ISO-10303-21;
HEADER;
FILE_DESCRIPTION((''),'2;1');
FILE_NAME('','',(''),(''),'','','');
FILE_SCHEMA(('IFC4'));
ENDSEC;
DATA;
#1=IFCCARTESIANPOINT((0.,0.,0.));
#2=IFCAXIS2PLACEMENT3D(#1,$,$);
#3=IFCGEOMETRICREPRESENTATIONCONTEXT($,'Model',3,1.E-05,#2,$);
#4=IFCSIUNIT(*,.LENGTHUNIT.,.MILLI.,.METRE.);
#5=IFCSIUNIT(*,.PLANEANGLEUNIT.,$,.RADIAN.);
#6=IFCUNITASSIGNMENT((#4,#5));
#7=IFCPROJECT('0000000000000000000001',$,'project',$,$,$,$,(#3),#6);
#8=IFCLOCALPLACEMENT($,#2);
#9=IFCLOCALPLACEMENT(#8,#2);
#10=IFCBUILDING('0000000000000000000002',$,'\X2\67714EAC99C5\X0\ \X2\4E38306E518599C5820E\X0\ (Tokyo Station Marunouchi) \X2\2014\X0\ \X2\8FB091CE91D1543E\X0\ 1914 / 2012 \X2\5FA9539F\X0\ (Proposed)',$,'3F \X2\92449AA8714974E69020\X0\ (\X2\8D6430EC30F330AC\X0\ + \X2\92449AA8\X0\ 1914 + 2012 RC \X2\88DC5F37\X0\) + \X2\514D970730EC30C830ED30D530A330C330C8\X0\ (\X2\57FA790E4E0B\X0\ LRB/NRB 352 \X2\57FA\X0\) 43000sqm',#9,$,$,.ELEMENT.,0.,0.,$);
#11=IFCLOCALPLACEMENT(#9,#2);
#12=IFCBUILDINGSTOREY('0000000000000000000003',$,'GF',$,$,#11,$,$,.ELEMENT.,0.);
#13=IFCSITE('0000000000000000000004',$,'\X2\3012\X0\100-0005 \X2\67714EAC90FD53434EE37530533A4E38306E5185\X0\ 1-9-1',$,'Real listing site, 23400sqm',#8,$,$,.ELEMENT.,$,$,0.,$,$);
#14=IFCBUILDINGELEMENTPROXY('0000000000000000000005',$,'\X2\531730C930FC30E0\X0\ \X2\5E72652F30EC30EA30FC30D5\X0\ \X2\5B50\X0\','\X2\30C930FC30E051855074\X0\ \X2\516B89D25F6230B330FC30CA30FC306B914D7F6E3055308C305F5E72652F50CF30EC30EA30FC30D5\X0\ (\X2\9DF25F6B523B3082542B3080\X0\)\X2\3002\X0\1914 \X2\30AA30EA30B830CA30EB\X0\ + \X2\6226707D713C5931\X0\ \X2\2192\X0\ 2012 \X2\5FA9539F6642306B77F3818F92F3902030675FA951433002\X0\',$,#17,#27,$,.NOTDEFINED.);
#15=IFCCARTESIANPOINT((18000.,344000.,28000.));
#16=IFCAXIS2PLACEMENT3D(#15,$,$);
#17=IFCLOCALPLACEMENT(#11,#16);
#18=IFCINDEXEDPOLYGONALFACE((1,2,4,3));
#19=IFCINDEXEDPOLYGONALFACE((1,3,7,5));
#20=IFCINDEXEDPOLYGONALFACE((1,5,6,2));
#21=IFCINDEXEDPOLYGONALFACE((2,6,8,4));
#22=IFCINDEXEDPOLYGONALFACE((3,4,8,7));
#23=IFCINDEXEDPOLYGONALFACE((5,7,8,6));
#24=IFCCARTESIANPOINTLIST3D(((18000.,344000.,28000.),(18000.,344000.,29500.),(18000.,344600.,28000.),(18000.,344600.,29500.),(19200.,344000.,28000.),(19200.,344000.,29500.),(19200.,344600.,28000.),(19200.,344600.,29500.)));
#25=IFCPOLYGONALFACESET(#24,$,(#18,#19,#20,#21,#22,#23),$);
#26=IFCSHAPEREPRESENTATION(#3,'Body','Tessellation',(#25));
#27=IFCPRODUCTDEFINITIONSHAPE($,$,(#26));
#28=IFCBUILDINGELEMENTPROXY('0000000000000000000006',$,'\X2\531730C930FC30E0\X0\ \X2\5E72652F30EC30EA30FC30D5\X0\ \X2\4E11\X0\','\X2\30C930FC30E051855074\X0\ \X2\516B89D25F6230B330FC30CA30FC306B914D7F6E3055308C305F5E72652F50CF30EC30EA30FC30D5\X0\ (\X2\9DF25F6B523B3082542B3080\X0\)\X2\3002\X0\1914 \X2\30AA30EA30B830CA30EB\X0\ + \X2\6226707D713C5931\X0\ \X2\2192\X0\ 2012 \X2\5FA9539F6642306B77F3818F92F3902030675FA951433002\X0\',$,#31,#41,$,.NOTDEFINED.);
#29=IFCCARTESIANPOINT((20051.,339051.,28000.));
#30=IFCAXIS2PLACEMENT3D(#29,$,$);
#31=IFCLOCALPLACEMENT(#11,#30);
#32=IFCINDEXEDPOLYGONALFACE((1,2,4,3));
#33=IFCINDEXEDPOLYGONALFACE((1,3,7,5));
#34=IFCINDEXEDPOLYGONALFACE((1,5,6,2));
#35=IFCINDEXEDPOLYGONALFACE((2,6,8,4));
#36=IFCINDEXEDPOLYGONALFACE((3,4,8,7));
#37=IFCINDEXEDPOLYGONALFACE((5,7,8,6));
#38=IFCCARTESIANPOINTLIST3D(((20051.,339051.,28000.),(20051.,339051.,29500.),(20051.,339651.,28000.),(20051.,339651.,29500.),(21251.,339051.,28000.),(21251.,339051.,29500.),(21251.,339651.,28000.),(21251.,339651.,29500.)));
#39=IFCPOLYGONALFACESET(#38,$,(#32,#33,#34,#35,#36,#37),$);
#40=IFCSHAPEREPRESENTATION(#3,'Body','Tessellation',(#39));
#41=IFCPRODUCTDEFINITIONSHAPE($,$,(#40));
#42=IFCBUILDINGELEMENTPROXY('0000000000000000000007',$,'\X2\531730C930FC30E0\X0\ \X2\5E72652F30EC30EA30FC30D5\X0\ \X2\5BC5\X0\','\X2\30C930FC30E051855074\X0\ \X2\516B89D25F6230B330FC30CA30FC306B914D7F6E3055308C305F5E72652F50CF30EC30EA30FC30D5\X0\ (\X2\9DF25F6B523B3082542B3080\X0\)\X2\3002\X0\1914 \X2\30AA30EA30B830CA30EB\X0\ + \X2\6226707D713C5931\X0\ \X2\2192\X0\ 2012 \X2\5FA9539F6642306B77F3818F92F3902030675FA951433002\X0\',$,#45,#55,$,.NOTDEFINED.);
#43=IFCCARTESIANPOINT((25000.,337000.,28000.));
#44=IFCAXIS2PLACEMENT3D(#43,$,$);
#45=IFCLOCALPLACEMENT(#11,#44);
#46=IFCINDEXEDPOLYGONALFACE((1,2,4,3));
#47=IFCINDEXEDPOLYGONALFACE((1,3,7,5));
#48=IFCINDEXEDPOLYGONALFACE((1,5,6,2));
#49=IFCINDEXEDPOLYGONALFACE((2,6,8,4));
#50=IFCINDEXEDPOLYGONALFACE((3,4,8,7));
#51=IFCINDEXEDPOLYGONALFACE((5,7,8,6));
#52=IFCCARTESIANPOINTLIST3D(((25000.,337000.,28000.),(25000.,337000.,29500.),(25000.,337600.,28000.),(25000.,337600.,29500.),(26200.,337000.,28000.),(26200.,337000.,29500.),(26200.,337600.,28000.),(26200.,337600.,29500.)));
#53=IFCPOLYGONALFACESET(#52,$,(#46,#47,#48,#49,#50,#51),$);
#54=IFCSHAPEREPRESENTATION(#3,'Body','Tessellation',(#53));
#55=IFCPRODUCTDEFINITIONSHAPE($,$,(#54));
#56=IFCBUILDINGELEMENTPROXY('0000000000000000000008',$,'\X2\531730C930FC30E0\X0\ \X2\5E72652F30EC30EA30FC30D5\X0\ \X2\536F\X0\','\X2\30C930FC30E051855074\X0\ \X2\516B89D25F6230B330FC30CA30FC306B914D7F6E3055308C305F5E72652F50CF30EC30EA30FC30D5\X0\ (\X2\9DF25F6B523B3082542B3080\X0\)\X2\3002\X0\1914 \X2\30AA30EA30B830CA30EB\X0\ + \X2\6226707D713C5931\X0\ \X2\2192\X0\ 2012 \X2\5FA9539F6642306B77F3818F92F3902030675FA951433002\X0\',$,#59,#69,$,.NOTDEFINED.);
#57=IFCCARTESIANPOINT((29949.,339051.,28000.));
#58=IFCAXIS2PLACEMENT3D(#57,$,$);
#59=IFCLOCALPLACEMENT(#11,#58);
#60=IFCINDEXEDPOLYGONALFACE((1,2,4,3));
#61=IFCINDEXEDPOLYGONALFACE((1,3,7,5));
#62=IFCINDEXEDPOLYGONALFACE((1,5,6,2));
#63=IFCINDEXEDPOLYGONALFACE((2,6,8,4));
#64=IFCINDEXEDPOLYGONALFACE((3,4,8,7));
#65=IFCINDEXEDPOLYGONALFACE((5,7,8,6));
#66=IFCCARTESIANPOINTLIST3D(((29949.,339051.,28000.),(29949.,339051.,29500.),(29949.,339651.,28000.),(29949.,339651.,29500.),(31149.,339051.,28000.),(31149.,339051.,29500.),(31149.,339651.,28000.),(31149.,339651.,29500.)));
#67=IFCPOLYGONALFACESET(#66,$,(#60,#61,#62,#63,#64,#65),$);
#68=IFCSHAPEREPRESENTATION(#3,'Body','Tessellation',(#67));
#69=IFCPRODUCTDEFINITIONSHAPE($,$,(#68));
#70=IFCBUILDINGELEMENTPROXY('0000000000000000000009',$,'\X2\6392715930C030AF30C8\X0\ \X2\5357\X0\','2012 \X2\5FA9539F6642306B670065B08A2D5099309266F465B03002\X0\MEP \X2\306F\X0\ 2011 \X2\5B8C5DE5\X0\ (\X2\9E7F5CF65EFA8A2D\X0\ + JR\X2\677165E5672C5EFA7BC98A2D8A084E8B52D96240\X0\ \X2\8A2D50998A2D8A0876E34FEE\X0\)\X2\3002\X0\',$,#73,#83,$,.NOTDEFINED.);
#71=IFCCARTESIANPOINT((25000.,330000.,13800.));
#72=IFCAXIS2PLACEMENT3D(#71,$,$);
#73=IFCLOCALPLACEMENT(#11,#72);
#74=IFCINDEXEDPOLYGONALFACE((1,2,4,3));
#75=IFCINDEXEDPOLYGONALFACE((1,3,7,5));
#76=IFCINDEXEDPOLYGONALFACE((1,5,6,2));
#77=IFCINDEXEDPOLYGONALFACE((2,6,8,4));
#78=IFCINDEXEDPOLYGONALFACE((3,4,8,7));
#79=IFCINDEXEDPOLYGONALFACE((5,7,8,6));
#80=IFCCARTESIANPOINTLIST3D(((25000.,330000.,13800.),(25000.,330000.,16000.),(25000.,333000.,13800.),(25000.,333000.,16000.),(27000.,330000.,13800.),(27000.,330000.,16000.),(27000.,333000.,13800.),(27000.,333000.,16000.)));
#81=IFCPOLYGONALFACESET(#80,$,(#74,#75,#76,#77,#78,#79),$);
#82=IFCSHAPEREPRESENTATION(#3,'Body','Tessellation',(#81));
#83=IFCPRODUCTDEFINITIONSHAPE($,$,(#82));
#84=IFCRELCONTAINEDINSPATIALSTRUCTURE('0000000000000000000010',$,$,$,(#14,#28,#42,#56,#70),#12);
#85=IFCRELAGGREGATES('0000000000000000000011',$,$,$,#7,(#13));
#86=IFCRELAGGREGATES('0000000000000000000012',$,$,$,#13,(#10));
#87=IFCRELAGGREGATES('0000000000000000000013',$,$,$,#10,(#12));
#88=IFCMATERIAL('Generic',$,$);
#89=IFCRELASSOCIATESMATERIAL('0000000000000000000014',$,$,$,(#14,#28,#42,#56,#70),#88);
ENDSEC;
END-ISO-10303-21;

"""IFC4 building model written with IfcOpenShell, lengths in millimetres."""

from ifc_helpers import new_model, si_unit, frame, frame_2d, origin, place, context, project, spatial, rectangle, extrude, material, element, save


model = new_model("IFC4")

# Units and contexts
model_context = context("Model", 3, precision=1e-05, world=origin())
ifc_project = project(units=[si_unit("LENGTHUNIT", "METRE", prefix="MILLI"), si_unit("PLANEANGLEUNIT", "RADIAN")], contexts=[model_context])

# Site, building, storey
site_placement = place(None, origin())
site = spatial("IfcSite", under=ifc_project, at=site_placement, Name="〒100-0005 東京都千代田区丸の内 1-9-1", ObjectType="Real listing site, 23400sqm", CompositionType="ELEMENT", RefElevation=0.0)
building_placement = place(site_placement, origin())
building = spatial("IfcBuilding", under=site, at=building_placement, Name="東京駅 丸の内駅舎 (Tokyo Station Marunouchi) — 辰野金吾 1914 / 2012 復原 (Proposed)", ObjectType="3F 鉄骨煉瓦造 (赤レンガ + 鉄骨 1914 + 2012 RC 補強) + 免震レトロフィット (基礎下 LRB/NRB 352 基) 43000sqm", CompositionType="ELEMENT", ElevationOfRefHeight=0.0, ElevationOfTerrain=0.0)
storey_placement = place(building_placement, origin())
storey = spatial("IfcBuildingStorey", under=building, at=storey_placement, Name="GF", CompositionType="ELEMENT", Elevation=0.0)

# Shared definitions
ifc_material_1 = material(Name="Generic")

# Building element proxies
proxy_1_placement = place(storey_placement, frame((18000.0, 344000.0, 28000.0)))
element("IfcBuildingElementProxy", 1, at=proxy_1_placement, inside=storey, material=ifc_material_1, Name="北ドーム 干支レリーフ 子", Description="ドーム内側 八角形コーナーに配置された干支像レリーフ (鷲彫刻も含む)。1914 オリジナル + 戦災焼失 → 2012 復原時に石膏鋳造で復元。", PredefinedType="NOTDEFINED", context=model_context, shape_type="SweptSolid", body=[
    extrude(rectangle(XDim=1200.0, YDim=600.0, at=frame_2d((600.0, 300.0))), frame((18000.0, 344000.0, 28000.0)), (0.0, 0.0, 1.0), 1500.0),
])
proxy_2_placement = place(storey_placement, frame((20051.0, 339051.0, 28000.0)))
element("IfcBuildingElementProxy", 2, at=proxy_2_placement, inside=storey, material=ifc_material_1, Name="北ドーム 干支レリーフ 丑", Description="ドーム内側 八角形コーナーに配置された干支像レリーフ (鷲彫刻も含む)。1914 オリジナル + 戦災焼失 → 2012 復原時に石膏鋳造で復元。", PredefinedType="NOTDEFINED", context=model_context, shape_type="SweptSolid", body=[
    extrude(rectangle(XDim=1200.0, YDim=600.0, at=frame_2d((600.0, 300.0))), frame((20051.0, 339051.0, 28000.0)), (0.0, 0.0, 1.0), 1500.0),
])
proxy_3_placement = place(storey_placement, frame((25000.0, 337000.0, 28000.0)))
element("IfcBuildingElementProxy", 3, at=proxy_3_placement, inside=storey, material=ifc_material_1, Name="北ドーム 干支レリーフ 寅", Description="ドーム内側 八角形コーナーに配置された干支像レリーフ (鷲彫刻も含む)。1914 オリジナル + 戦災焼失 → 2012 復原時に石膏鋳造で復元。", PredefinedType="NOTDEFINED", context=model_context, shape_type="SweptSolid", body=[
    extrude(rectangle(XDim=1200.0, YDim=600.0, at=frame_2d((600.0, 300.0))), frame((25000.0, 337000.0, 28000.0)), (0.0, 0.0, 1.0), 1500.0),
])
proxy_4_placement = place(storey_placement, frame((29949.0, 339051.0, 28000.0)))
element("IfcBuildingElementProxy", 4, at=proxy_4_placement, inside=storey, material=ifc_material_1, Name="北ドーム 干支レリーフ 卯", Description="ドーム内側 八角形コーナーに配置された干支像レリーフ (鷲彫刻も含む)。1914 オリジナル + 戦災焼失 → 2012 復原時に石膏鋳造で復元。", PredefinedType="NOTDEFINED", context=model_context, shape_type="SweptSolid", body=[
    extrude(rectangle(XDim=1200.0, YDim=600.0, at=frame_2d((600.0, 300.0))), frame((29949.0, 339051.0, 28000.0)), (0.0, 0.0, 1.0), 1500.0),
])
proxy_5_placement = place(storey_placement, frame((25000.0, 330000.0, 13800.0)))
element("IfcBuildingElementProxy", 5, at=proxy_5_placement, inside=storey, material=ifc_material_1, Name="排煙ダクト 南", Description="2012 復原時に最新設備を更新。MEP は 2011 完工 (鹿島建設 + JR東日本建築設計事務所 設備設計監修)。", PredefinedType="NOTDEFINED", context=model_context, shape_type="SweptSolid", body=[
    extrude(rectangle(XDim=2000.0, YDim=3000.0, at=frame_2d((1000.0, 1500.0))), frame((25000.0, 330000.0, 13800.0)), (0.0, 0.0, 1.0), 2200.0),
])

save(model, "model.ifc")
